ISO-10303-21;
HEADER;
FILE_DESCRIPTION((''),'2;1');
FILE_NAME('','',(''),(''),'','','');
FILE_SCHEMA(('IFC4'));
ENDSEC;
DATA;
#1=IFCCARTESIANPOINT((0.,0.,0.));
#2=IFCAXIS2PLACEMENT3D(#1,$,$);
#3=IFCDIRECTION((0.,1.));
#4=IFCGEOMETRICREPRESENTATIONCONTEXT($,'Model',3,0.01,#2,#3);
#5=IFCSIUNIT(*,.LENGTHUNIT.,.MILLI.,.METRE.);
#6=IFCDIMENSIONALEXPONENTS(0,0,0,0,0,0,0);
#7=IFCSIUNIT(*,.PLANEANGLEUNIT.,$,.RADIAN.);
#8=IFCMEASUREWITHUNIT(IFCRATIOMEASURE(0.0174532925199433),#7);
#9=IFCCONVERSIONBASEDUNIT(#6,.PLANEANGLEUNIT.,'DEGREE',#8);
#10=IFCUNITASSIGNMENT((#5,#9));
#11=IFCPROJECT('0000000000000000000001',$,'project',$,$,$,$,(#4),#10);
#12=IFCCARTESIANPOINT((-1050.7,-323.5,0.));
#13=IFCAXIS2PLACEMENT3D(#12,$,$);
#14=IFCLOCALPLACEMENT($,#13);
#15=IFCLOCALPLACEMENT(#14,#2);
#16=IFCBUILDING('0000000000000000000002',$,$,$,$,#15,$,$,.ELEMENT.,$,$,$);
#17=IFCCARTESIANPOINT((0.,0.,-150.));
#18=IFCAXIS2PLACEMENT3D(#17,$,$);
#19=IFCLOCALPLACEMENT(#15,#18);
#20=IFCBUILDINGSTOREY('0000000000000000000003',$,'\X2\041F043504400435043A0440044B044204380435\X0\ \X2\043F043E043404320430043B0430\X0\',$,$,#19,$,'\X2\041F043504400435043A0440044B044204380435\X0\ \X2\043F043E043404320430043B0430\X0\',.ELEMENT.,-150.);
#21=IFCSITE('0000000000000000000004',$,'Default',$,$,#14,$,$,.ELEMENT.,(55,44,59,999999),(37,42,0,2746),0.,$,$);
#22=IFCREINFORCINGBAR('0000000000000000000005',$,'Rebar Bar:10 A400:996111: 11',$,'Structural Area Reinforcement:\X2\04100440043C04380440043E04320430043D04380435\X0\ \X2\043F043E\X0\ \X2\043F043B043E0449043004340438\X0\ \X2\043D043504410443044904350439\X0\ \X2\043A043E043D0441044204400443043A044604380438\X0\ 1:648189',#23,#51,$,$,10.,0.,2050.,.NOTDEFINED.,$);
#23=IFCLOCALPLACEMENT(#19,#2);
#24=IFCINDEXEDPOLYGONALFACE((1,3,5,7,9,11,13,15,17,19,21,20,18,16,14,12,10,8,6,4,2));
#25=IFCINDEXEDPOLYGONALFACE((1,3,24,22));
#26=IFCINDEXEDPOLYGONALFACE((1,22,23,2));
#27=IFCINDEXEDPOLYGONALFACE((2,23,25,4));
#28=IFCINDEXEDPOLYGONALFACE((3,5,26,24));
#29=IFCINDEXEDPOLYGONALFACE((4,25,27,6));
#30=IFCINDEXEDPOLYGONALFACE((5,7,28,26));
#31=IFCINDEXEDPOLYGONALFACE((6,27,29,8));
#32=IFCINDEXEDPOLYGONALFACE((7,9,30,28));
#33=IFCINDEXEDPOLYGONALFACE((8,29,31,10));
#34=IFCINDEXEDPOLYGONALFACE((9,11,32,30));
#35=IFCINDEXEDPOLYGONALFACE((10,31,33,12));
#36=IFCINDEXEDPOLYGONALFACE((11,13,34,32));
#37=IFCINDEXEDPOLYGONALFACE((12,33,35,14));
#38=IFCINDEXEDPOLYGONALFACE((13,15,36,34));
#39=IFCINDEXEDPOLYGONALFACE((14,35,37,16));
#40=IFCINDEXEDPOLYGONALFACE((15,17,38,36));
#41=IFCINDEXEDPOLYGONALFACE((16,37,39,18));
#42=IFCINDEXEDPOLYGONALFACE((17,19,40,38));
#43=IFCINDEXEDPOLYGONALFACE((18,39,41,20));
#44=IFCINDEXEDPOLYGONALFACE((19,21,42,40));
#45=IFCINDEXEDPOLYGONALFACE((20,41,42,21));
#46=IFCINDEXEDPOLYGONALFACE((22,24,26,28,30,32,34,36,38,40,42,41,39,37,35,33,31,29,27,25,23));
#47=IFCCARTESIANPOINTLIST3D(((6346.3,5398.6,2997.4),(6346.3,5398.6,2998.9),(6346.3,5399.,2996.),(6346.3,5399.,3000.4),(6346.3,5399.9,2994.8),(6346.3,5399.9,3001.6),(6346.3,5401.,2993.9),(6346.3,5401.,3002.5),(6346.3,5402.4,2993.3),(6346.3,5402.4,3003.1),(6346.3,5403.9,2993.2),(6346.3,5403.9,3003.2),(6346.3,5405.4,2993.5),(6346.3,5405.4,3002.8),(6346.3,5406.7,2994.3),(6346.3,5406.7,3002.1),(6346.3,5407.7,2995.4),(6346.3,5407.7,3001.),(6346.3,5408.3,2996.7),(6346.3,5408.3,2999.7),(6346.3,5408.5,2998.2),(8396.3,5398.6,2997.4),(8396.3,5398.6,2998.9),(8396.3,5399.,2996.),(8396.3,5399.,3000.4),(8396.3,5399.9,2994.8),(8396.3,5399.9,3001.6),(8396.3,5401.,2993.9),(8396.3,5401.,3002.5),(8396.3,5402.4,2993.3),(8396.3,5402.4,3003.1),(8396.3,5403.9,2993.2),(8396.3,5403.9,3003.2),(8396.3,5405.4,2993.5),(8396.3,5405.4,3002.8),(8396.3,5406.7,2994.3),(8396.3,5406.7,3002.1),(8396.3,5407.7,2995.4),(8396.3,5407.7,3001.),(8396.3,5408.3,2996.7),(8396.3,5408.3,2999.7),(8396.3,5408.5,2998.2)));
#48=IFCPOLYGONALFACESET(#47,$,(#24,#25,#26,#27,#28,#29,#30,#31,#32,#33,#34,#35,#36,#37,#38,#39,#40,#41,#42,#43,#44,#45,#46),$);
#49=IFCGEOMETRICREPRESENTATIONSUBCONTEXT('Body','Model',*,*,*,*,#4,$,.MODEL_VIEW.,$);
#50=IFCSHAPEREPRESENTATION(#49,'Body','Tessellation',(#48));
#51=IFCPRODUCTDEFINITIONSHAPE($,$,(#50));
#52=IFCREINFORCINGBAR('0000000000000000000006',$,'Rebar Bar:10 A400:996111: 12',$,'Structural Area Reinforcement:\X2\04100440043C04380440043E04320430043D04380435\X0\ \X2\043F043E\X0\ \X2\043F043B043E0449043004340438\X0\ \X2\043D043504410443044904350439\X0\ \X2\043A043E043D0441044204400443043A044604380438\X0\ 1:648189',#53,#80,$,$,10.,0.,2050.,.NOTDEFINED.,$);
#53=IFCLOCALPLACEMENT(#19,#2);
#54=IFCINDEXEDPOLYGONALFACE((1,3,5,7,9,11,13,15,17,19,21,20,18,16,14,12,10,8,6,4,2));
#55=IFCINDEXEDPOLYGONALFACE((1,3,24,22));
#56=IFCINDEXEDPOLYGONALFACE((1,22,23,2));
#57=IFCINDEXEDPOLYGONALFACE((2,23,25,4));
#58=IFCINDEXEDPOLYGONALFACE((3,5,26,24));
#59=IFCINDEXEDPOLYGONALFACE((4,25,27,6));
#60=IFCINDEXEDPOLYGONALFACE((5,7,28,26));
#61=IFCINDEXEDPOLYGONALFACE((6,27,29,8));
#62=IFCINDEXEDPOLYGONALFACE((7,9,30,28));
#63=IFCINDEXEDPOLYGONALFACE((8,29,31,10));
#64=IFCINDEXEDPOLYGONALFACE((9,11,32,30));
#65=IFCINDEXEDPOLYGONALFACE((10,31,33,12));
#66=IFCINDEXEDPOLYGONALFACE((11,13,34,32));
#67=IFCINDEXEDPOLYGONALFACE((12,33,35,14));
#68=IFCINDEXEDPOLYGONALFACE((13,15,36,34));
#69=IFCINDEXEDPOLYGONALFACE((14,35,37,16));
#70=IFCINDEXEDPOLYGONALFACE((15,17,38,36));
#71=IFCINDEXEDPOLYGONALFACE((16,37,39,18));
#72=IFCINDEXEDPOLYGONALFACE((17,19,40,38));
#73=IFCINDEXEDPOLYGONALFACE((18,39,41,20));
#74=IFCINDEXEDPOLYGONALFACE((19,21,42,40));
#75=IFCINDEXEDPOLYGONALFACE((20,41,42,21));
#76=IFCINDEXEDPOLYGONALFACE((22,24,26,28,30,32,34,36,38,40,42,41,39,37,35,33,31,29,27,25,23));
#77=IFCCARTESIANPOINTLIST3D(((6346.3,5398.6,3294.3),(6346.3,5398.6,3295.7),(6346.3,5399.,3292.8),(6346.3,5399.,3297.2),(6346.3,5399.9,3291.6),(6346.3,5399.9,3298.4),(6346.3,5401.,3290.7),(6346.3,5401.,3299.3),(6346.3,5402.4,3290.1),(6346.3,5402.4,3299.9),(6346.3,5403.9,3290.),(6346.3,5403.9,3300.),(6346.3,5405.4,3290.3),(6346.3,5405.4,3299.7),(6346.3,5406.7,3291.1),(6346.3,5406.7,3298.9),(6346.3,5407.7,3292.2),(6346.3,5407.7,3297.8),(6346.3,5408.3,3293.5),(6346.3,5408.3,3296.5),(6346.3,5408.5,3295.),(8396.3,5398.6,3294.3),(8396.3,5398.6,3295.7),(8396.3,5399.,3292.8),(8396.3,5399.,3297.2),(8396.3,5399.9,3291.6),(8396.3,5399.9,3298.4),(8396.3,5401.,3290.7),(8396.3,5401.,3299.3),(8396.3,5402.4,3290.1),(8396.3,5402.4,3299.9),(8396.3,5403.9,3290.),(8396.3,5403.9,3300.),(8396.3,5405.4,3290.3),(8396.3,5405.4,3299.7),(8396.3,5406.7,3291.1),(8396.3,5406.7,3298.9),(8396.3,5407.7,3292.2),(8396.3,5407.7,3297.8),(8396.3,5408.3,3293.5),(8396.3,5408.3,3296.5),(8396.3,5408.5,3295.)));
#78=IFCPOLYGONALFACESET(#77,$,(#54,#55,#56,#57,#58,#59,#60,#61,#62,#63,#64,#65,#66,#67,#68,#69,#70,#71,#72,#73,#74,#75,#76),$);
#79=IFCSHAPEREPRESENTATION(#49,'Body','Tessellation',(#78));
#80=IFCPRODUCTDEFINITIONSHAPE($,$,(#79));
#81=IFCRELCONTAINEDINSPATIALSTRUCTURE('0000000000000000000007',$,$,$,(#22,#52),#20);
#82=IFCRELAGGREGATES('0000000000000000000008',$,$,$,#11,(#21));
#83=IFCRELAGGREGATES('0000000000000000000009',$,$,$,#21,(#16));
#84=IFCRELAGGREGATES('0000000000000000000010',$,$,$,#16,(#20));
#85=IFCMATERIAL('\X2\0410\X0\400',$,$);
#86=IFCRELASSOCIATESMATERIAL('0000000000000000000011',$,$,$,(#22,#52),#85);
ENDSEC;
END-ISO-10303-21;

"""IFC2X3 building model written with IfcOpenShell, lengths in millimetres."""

from ifc_helpers import new_model, entity, si_unit, converted_unit, direction, frame, origin, place, context, subcontext, project, spatial, material, element, save


model = new_model("IFC2X3")

# Units and contexts
model_context = context("Model", 3, precision=0.01, world=origin(), true_north=direction((0.0, 1.0)))
body_context = subcontext(model_context, "Body", "Model", "MODEL_VIEW")
ifc_project = project(units=[si_unit("LENGTHUNIT", "METRE", prefix="MILLI"), converted_unit("PLANEANGLEUNIT", "DEGREE", entity("IfcRatioMeasure", 0.0174532925199433), si_unit("PLANEANGLEUNIT", "RADIAN"), dimensions=[0, 0, 0, 0, 0, 0, 0])], contexts=[model_context])

# Site, building, storey
site_placement = place(None, frame((-1050.7, -323.5, 0.0)))
site = spatial("IfcSite", under=ifc_project, at=site_placement, Name="Default", CompositionType="ELEMENT", RefLatitude=(55, 44, 59, 999999), RefLongitude=(37, 42, 0, 2746), RefElevation=0.0)
building_placement = place(site_placement, origin())
building = spatial("IfcBuilding", under=site, at=building_placement, CompositionType="ELEMENT")
storey_placement = place(building_placement, frame((0.0, 0.0, -150.0)))
storey = spatial("IfcBuildingStorey", under=building, at=storey_placement, Name="Перекрытие подвала", LongName="Перекрытие подвала", CompositionType="ELEMENT", Elevation=-150.0)

# Reinforcing bars
ifc_material = material(Name="А400")
reinforcing_bar_1_placement = place(storey_placement, origin())
element("IfcReinforcingBar", 1, at=reinforcing_bar_1_placement, inside=storey, material=ifc_material, Name="Rebar Bar:10 A400:996111: 11", ObjectType="Structural Area Reinforcement:Армирование по площади несущей конструкции 1:648189", BarLength=2050.0, BarRole="NOTDEFINED", CrossSectionArea=0.0, NominalDiameter=10.0, context=body_context, shape_type="AdvancedSweptSolid", body=[
    entity("IfcSweptDiskSolid", entity("IfcCompositeCurve", [entity("IfcCompositeCurveSegment", "CONTINUOUS", True, entity("IfcPolyline", [entity("IfcCartesianPoint", [6346.3, 5403.5, 2998.2]), entity("IfcCartesianPoint", [8396.3, 5403.5, 2998.2])]))], False), 5.0, None, 0.0, 1.0),
])
reinforcing_bar_2_placement = place(storey_placement, origin())
element("IfcReinforcingBar", 2, at=reinforcing_bar_2_placement, inside=storey, material=ifc_material, Name="Rebar Bar:10 A400:996111: 12", ObjectType="Structural Area Reinforcement:Армирование по площади несущей конструкции 1:648189", BarLength=2050.0, BarRole="NOTDEFINED", CrossSectionArea=0.0, NominalDiameter=10.0, context=body_context, shape_type="AdvancedSweptSolid", body=[
    entity("IfcSweptDiskSolid", entity("IfcCompositeCurve", [entity("IfcCompositeCurveSegment", "CONTINUOUS", True, entity("IfcPolyline", [entity("IfcCartesianPoint", [6346.3, 5403.5, 3295.0]), entity("IfcCartesianPoint", [8396.3, 5403.5, 3295.0])]))], False), 5.0, None, 0.0, 1.0),
])

save(model, "model.ifc")
